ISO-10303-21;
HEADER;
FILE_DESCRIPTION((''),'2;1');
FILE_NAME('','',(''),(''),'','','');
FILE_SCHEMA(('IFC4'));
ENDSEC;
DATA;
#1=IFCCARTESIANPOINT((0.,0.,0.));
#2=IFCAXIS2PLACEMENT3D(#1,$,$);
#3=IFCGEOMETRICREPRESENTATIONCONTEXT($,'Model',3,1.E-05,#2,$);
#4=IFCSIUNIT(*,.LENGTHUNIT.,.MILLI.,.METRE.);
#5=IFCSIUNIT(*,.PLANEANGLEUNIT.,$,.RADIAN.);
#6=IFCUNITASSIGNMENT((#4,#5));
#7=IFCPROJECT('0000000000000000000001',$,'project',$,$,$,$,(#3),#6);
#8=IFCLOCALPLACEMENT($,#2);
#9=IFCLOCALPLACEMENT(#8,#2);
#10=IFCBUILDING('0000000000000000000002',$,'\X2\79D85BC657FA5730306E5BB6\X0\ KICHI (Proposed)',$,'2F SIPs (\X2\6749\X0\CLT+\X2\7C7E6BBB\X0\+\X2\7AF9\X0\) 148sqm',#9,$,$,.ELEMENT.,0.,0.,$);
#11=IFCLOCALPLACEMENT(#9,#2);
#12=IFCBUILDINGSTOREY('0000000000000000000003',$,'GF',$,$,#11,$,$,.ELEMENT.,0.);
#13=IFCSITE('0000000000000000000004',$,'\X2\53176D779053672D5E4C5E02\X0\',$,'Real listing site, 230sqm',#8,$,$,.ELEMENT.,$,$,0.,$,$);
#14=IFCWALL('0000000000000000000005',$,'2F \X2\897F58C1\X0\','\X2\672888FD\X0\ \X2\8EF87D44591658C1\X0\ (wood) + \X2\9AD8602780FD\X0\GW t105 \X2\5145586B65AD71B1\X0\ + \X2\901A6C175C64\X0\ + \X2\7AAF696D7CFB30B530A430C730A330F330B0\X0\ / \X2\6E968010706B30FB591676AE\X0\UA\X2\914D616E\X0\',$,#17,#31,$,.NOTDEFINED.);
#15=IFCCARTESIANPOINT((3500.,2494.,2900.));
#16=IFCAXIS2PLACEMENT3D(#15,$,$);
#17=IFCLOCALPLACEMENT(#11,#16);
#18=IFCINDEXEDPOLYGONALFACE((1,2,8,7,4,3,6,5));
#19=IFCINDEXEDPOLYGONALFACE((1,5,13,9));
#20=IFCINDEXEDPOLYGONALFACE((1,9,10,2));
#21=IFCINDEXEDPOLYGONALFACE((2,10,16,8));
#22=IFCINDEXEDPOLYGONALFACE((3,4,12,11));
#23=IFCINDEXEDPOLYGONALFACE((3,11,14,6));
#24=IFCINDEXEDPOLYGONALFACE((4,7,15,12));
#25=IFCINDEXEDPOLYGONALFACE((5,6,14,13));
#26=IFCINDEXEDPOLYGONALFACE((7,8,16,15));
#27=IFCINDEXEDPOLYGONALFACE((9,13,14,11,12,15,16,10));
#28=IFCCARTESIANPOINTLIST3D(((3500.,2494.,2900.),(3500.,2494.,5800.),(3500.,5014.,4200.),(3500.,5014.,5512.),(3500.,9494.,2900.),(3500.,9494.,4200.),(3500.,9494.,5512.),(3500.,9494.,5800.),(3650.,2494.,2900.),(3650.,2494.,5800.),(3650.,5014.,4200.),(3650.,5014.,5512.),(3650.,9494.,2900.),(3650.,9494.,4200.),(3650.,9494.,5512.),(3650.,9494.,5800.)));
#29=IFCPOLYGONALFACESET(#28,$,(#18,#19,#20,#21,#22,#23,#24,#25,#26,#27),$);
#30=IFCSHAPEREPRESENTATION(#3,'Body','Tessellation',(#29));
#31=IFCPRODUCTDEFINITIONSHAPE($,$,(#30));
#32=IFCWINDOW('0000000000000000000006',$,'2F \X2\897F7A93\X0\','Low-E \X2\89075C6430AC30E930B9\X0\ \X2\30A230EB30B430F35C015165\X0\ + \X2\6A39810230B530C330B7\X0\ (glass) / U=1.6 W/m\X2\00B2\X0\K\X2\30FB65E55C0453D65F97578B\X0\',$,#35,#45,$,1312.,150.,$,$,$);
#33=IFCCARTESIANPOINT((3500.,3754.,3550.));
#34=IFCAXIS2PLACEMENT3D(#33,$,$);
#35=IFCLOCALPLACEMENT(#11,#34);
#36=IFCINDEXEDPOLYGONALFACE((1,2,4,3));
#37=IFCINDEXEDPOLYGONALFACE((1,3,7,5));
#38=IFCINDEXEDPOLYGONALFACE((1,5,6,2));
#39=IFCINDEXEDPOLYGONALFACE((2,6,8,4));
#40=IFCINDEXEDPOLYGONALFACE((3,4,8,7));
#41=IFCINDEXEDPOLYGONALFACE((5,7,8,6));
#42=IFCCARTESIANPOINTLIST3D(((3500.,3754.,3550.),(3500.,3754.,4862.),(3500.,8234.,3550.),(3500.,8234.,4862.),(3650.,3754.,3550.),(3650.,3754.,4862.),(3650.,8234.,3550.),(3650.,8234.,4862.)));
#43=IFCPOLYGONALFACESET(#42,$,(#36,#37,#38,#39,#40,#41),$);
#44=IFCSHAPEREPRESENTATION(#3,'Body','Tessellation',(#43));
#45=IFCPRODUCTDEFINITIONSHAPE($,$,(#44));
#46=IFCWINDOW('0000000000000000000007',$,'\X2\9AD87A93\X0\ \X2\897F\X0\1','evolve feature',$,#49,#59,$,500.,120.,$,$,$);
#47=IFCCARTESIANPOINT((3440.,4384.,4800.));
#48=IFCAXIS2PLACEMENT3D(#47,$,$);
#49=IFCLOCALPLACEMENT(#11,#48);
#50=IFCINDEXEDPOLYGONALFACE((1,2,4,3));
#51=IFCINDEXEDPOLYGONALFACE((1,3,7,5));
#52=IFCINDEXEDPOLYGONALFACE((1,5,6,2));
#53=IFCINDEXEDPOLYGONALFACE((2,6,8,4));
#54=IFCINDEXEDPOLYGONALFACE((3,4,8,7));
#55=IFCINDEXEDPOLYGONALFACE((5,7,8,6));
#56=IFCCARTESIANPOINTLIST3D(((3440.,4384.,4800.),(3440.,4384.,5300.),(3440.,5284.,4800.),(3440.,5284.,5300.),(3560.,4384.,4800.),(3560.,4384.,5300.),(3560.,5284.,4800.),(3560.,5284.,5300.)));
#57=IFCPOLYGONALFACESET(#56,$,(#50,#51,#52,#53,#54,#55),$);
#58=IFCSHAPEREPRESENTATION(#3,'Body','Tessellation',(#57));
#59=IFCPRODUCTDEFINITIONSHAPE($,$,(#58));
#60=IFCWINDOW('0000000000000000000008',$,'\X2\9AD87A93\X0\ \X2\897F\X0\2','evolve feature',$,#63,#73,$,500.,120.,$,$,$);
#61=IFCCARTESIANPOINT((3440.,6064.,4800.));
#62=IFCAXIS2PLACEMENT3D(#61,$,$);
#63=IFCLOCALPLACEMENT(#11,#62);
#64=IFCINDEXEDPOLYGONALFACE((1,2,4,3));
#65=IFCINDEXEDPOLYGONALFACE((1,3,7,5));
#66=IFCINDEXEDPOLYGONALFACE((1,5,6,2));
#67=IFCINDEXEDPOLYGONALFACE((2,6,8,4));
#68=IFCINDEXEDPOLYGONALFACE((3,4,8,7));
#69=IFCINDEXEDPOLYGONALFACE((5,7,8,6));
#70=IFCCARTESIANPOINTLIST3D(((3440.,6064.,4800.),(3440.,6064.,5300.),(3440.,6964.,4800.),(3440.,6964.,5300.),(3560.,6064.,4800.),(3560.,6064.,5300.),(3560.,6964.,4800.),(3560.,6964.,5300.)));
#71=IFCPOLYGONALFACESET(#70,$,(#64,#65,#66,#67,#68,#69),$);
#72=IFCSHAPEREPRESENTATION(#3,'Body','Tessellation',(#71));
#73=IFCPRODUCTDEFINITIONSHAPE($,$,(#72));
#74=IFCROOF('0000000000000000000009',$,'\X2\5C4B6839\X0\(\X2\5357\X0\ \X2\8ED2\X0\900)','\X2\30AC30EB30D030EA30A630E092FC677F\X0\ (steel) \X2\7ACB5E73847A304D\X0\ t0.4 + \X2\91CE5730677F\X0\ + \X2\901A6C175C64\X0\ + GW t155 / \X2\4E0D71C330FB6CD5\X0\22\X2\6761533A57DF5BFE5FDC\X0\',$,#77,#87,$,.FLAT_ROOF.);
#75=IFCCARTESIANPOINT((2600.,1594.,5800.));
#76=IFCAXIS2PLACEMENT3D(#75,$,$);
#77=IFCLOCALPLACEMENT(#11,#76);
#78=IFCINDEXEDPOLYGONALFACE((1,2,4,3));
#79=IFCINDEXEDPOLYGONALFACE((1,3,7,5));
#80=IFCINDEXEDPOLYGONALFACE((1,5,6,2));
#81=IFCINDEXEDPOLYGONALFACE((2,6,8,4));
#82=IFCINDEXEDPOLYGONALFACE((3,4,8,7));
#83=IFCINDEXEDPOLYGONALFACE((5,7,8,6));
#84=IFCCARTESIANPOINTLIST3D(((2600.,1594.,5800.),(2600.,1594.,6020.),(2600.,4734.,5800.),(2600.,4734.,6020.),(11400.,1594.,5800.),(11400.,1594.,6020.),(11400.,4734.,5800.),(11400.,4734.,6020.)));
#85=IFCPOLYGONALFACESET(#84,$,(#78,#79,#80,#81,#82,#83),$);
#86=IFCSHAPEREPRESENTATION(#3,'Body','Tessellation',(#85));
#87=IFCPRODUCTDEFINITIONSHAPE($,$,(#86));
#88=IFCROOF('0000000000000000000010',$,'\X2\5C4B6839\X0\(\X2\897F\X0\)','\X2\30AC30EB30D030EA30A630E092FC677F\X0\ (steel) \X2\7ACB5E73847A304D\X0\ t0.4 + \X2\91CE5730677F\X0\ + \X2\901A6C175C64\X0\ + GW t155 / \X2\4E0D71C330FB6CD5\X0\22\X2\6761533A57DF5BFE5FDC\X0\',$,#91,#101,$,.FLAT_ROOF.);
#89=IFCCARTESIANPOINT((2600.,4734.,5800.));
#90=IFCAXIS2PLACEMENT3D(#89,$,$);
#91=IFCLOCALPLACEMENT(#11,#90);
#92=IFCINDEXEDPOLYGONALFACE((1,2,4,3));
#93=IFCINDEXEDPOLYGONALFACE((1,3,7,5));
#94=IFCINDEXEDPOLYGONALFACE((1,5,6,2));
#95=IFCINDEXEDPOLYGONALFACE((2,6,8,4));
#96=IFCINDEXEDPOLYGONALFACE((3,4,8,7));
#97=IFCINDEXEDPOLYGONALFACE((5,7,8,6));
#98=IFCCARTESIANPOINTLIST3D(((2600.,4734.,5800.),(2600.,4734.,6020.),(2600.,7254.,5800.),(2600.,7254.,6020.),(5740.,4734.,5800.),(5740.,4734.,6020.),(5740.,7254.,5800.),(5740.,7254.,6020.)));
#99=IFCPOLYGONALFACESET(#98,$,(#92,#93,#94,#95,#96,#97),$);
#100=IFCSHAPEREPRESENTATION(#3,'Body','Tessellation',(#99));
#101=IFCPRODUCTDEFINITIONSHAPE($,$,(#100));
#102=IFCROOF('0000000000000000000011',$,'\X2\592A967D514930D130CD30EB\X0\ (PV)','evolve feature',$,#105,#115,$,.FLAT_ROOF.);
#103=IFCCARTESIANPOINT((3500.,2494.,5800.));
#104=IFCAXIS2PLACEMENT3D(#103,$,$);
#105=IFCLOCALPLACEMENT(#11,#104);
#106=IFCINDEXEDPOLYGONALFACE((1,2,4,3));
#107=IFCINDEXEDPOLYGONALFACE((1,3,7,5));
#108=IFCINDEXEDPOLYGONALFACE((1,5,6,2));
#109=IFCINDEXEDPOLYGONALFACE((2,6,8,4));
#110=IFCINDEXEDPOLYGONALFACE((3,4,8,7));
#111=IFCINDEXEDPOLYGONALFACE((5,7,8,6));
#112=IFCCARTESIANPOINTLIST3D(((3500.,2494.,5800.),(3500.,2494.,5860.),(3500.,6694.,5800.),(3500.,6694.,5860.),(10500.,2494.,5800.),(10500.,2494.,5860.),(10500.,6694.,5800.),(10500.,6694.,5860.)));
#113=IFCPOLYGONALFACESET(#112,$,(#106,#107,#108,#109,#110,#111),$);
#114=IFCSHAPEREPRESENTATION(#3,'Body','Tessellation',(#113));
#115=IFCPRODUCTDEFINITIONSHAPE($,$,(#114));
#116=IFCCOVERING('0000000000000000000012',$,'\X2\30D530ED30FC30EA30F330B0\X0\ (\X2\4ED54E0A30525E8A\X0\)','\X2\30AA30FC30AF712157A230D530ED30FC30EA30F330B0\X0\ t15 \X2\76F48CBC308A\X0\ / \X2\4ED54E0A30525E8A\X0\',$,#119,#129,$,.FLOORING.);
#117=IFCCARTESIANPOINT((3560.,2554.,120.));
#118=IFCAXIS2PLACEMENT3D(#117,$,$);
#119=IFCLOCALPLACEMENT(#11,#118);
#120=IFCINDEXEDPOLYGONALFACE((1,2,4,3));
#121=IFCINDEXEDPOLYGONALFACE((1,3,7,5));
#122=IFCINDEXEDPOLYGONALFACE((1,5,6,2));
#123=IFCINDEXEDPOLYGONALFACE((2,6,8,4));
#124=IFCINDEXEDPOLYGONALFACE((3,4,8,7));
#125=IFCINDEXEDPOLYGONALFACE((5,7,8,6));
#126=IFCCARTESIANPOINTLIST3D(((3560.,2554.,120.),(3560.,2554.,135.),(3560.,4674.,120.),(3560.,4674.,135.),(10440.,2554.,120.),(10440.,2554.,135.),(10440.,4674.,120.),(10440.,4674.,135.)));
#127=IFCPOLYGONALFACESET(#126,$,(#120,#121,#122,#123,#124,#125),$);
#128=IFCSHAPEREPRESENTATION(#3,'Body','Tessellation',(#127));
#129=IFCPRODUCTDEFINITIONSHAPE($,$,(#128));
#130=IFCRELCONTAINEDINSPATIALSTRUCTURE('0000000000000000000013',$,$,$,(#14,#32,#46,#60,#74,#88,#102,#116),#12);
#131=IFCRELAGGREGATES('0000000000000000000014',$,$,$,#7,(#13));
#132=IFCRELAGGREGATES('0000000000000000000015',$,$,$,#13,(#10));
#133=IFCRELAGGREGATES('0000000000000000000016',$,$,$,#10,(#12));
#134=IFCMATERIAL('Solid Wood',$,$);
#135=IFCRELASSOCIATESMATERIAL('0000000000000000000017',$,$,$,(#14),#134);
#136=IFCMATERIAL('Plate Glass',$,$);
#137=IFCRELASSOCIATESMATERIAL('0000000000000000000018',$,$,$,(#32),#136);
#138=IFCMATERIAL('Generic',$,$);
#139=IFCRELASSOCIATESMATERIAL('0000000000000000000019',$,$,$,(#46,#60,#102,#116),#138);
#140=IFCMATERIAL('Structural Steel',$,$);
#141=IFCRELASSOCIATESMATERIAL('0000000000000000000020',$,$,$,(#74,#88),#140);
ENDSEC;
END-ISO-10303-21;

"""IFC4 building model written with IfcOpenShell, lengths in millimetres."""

from ifc_helpers import new_model, si_unit, frame, frame_2d, origin, place, context, project, spatial, rectangle, extrude, material, element, fill, save


model = new_model("IFC4")

# Units and contexts
model_context = context("Model", 3, precision=1e-05, world=origin())
ifc_project = project(units=[si_unit("LENGTHUNIT", "METRE", prefix="MILLI"), si_unit("PLANEANGLEUNIT", "RADIAN")], contexts=[model_context])

# Site, building, storey
site_placement = place(None, origin())
site = spatial("IfcSite", under=ifc_project, at=site_placement, Name="北海道札幌市", ObjectType="Real listing site, 230sqm", CompositionType="ELEMENT", RefElevation=0.0)
building_placement = place(site_placement, origin())
building = spatial("IfcBuilding", under=site, at=building_placement, Name="秘密基地の家 KICHI (Proposed)", ObjectType="2F SIPs (杉CLT+籾殻+竹) 148sqm", CompositionType="ELEMENT", ElevationOfRefHeight=0.0, ElevationOfTerrain=0.0)
storey_placement = place(building_placement, origin())
storey = spatial("IfcBuildingStorey", under=building, at=storey_placement, Name="GF", CompositionType="ELEMENT", Elevation=0.0)

# Shared definitions
ifc_material_1 = material(Name="Solid Wood")
ifc_material_2 = material(Name="Generic")

# Shared definitions
ifc_material_3 = material(Name="Plate Glass")

# Wall, openings, windows
wall_1_placement = place(storey_placement, frame((3500.0, 2494.0, 2900.0)))
wall_1 = element("IfcWall", 1, at=wall_1_placement, inside=storey, material=ifc_material_1, Name="2F 西壁", Description="木製 軸組外壁 (wood) + 高性能GW t105 充填断熱 + 通気層 + 窯業系サイディング / 準耐火・外皮UA配慮", PredefinedType="NOTDEFINED", context=model_context, shape_type="SweptSolid", body=[
    extrude(rectangle(XDim=150.0, YDim=7000.0, at=frame_2d((75.0, 3500.0))), frame((3500.0, 2494.0, 2900.0)), (0.0, 0.0, 1.0), 2900.0),
])
opening_1_placement = place(storey_placement, frame((3500.0, 3754.0, 3550.0)))
opening_1 = element("IfcOpeningElement", 2, at=opening_1_placement, cuts=wall_1, PredefinedType="NOTDEFINED", context=model_context, shape_type="SweptSolid", body=[
    extrude(rectangle(XDim=150.0, YDim=4480.0, at=frame_2d((75.0, 2240.0))), frame((3500.0, 3754.0, 3550.0)), (0.0, 0.0, 1.0), 1312.0),
])
opening_2_placement = place(storey_placement, frame((3440.0, 4384.0, 4800.0)))
opening_2 = element("IfcOpeningElement", 3, at=opening_2_placement, cuts=wall_1, PredefinedType="NOTDEFINED", context=model_context, shape_type="SweptSolid", body=[
    extrude(rectangle(XDim=120.0, YDim=900.0, at=frame_2d((60.0, 450.0))), frame((3440.0, 4384.0, 4800.0)), (0.0, 0.0, 1.0), 500.0),
])
opening_3_placement = place(storey_placement, frame((3440.0, 6064.0, 4800.0)))
opening_3 = element("IfcOpeningElement", 4, at=opening_3_placement, cuts=wall_1, PredefinedType="NOTDEFINED", context=model_context, shape_type="SweptSolid", body=[
    extrude(rectangle(XDim=120.0, YDim=900.0, at=frame_2d((60.0, 450.0))), frame((3440.0, 6064.0, 4800.0)), (0.0, 0.0, 1.0), 500.0),
])
window_1_placement = place(storey_placement, frame((3500.0, 3754.0, 3550.0)))
window_1 = element("IfcWindow", 5, at=window_1_placement, inside=storey, material=ifc_material_3, Name="2F 西窓", Description="Low-E 複層ガラス アルゴン封入 + 樹脂サッシ (glass) / U=1.6 W/m²K・日射取得型", OverallHeight=1312.0, OverallWidth=150.0, context=model_context, shape_type="SweptSolid", body=[
    extrude(rectangle(XDim=150.0, YDim=4480.0, at=frame_2d((75.0, 2240.0))), frame((3500.0, 3754.0, 3550.0)), (0.0, 0.0, 1.0), 1312.0),
])
fill(opening_1, window_1)
window_2_placement = place(storey_placement, frame((3440.0, 4384.0, 4800.0)))
window_2 = element("IfcWindow", 6, at=window_2_placement, inside=storey, material=ifc_material_2, Name="高窓 西1", Description="evolve feature", OverallHeight=500.0, OverallWidth=120.0, context=model_context, shape_type="SweptSolid", body=[
    extrude(rectangle(XDim=120.0, YDim=900.0, at=frame_2d((60.0, 450.0))), frame((3440.0, 4384.0, 4800.0)), (0.0, 0.0, 1.0), 500.0),
])
fill(opening_2, window_2)
window_3_placement = place(storey_placement, frame((3440.0, 6064.0, 4800.0)))
window_3 = element("IfcWindow", 7, at=window_3_placement, inside=storey, material=ifc_material_2, Name="高窓 西2", Description="evolve feature", OverallHeight=500.0, OverallWidth=120.0, context=model_context, shape_type="SweptSolid", body=[
    extrude(rectangle(XDim=120.0, YDim=900.0, at=frame_2d((60.0, 450.0))), frame((3440.0, 6064.0, 4800.0)), (0.0, 0.0, 1.0), 500.0),
])
fill(opening_3, window_3)

# Roofs
ifc_material_4 = material(Name="Structural Steel")
roof_1_placement = place(storey_placement, frame((2600.0, 1594.0, 5800.0)))
element("IfcRoof", 8, at=roof_1_placement, inside=storey, material=ifc_material_4, Name="屋根(南 軒900)", Description="ガルバリウム鋼板 (steel) 立平葺き t0.4 + 野地板 + 通気層 + GW t155 / 不燃・法22条区域対応", PredefinedType="FLAT_ROOF", context=model_context, shape_type="SweptSolid", body=[
    extrude(rectangle(XDim=8800.0, YDim=3140.0, at=frame_2d((4400.0, 1570.0))), frame((2600.0, 1594.0, 5800.0)), (0.0, 0.0, 1.0), 220.0),
])
roof_2_placement = place(storey_placement, frame((2600.0, 4734.0, 5800.0)))
element("IfcRoof", 9, at=roof_2_placement, inside=storey, material=ifc_material_4, Name="屋根(西)", Description="ガルバリウム鋼板 (steel) 立平葺き t0.4 + 野地板 + 通気層 + GW t155 / 不燃・法22条区域対応", PredefinedType="FLAT_ROOF", context=model_context, shape_type="SweptSolid", body=[
    extrude(rectangle(XDim=3140.0, YDim=2520.0, at=frame_2d((1570.0, 1260.0))), frame((2600.0, 4734.0, 5800.0)), (0.0, 0.0, 1.0), 220.0),
])
roof_3_placement = place(storey_placement, frame((3500.0, 2494.0, 5800.0)))
element("IfcRoof", 10, at=roof_3_placement, inside=storey, material=ifc_material_2, Name="太陽光パネル (PV)", Description="evolve feature", PredefinedType="FLAT_ROOF", context=model_context, shape_type="SweptSolid", body=[
    extrude(rectangle(XDim=7000.0, YDim=4200.0, at=frame_2d((3500.0, 2100.0))), frame((3500.0, 2494.0, 5800.0)), (0.0, 0.0, 1.0), 60.0),
])

# Covering
covering_placement = place(storey_placement, frame((3560.0, 2554.0, 120.0)))
element("IfcCovering", 11, at=covering_placement, inside=storey, material=ifc_material_2, Name="フローリング (仕上げ床)", Description="オーク無垢フローリング t15 直貼り / 仕上げ床", PredefinedType="FLOORING", context=model_context, shape_type="SweptSolid", body=[
    extrude(rectangle(XDim=6880.0, YDim=2120.0, at=frame_2d((3440.0, 1060.0))), frame((3560.0, 2554.0, 120.0)), (0.0, 0.0, 1.0), 15.0),
])

save(model, "model.ifc")
